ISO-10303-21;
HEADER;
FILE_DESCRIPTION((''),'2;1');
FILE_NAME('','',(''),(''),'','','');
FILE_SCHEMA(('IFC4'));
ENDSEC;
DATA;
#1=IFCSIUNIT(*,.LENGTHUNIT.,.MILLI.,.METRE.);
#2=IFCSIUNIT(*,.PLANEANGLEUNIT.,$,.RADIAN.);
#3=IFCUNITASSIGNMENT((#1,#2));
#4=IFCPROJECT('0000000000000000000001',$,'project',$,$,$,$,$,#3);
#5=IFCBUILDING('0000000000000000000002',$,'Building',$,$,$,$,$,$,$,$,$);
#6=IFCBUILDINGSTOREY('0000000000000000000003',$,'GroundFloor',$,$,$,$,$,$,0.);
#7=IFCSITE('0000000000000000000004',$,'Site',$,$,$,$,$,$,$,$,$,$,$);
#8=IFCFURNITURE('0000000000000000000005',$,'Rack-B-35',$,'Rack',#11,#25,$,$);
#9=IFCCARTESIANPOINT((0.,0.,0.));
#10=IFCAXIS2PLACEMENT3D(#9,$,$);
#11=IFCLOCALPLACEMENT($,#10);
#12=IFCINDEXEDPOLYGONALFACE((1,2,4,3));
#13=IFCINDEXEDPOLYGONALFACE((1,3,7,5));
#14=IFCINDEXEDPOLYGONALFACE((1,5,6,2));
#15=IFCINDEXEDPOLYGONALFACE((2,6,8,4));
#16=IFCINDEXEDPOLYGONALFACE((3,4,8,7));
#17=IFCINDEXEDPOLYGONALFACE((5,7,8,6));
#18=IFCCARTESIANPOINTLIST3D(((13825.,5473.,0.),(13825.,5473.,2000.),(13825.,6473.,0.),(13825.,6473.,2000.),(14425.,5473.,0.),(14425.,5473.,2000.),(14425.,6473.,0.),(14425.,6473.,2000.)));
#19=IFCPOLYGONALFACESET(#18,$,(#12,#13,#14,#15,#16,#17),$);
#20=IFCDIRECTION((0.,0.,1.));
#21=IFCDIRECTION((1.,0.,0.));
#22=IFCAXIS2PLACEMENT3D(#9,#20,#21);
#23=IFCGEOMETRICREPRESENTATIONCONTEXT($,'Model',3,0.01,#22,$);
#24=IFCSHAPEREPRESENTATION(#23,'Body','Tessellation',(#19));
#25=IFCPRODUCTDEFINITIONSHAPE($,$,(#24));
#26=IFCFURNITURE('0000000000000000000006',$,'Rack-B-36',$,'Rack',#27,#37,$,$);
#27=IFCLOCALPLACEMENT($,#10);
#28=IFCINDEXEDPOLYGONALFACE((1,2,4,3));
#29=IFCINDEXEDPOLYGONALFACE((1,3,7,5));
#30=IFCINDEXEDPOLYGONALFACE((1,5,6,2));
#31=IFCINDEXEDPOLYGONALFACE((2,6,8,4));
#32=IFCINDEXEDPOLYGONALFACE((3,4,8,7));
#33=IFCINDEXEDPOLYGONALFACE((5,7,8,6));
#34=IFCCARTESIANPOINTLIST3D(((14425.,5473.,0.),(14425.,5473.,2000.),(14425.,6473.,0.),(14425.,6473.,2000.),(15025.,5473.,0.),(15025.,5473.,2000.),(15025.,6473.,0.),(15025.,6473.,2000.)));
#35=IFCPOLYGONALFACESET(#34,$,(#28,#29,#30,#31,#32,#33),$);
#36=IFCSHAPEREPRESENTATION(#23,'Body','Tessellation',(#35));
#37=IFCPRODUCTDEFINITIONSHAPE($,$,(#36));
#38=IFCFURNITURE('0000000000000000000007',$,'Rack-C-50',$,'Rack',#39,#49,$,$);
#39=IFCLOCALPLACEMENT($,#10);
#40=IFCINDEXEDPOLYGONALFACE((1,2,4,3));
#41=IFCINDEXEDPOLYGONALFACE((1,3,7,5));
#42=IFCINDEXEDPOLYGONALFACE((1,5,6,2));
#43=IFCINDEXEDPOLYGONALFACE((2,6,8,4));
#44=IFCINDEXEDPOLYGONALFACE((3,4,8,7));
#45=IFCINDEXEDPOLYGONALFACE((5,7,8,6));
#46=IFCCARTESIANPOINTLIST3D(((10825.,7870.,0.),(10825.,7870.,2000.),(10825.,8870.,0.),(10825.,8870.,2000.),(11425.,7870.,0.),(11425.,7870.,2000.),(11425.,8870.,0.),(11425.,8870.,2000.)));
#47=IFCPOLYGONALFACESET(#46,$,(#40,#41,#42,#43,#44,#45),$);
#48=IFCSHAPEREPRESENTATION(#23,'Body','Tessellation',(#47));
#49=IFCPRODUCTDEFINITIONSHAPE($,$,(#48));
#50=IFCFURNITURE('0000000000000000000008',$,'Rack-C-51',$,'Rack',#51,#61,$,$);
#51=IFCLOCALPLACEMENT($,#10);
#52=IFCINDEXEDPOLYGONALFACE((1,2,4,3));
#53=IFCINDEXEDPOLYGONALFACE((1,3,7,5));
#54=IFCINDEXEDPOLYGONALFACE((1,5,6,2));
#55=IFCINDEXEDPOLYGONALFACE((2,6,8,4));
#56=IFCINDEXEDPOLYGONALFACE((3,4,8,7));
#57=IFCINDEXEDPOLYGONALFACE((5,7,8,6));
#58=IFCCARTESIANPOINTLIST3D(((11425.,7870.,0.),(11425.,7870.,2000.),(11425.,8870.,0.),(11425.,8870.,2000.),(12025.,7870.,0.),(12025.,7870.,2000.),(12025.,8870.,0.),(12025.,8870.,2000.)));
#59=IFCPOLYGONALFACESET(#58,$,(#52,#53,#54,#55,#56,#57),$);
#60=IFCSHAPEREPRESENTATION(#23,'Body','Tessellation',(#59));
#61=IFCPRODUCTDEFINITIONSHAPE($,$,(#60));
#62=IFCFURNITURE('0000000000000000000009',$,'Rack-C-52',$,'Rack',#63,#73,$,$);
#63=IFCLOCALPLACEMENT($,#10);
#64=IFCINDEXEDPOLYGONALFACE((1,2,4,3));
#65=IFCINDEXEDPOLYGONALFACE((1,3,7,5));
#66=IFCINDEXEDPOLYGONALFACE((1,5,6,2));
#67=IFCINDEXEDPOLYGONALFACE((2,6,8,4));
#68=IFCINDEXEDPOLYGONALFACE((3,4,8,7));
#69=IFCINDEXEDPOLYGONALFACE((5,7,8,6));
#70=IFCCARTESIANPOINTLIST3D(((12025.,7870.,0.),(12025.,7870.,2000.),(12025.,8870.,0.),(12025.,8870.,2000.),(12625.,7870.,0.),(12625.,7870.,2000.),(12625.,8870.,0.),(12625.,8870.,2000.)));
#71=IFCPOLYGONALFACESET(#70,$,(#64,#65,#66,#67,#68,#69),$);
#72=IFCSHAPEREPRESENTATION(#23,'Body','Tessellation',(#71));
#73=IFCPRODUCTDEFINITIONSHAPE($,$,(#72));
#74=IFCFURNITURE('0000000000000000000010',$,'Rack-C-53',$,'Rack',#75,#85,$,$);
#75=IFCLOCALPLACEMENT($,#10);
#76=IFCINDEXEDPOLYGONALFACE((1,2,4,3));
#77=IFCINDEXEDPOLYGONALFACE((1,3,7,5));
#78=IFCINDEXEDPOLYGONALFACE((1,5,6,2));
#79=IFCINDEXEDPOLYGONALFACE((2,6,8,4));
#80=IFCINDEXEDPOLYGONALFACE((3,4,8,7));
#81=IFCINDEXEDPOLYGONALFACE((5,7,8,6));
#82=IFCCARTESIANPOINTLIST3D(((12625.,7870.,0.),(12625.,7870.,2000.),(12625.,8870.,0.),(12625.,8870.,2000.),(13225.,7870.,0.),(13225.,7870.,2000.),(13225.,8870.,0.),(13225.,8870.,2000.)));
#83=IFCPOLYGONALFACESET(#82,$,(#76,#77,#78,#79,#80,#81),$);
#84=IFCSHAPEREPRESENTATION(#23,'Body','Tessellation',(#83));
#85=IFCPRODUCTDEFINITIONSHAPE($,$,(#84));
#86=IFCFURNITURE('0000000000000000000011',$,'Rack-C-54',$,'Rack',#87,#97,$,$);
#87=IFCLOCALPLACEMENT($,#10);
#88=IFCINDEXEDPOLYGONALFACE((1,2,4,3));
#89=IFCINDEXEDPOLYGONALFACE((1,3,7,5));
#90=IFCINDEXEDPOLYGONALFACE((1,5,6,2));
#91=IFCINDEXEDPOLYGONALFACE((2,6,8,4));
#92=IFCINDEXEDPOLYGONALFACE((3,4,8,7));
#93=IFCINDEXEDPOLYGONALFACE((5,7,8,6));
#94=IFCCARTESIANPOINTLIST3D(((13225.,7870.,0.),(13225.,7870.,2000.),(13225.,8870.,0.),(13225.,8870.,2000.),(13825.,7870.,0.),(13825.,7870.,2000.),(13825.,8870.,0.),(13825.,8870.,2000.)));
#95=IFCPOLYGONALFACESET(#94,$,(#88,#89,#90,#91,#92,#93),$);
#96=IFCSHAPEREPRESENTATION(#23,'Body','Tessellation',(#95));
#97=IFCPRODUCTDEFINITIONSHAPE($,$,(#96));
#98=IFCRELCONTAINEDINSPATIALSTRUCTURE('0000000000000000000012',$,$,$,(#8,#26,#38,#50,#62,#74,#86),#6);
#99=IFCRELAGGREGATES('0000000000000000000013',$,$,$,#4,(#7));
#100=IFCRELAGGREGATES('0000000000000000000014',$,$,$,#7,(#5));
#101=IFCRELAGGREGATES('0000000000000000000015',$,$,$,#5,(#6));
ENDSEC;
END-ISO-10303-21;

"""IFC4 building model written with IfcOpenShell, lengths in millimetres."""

from ifc_helpers import new_model, si_unit, frame, origin, origin_with_axes, origin_2d, place, context, project, spatial, rectangle, extrude, element, save


model = new_model("IFC4")

# Units and contexts
model_context = context("Model", 3, precision=0.01, world=origin_with_axes())
ifc_project = project(units=[si_unit("LENGTHUNIT", "METRE", prefix="MILLI"), si_unit("PLANEANGLEUNIT", "RADIAN")])

# Site, building, storey
site = spatial("IfcSite", under=ifc_project, Name="Site")
building = spatial("IfcBuilding", under=site, Name="Building")
storey = spatial("IfcBuildingStorey", under=building, Name="GroundFloor", Elevation=0.0)

# Furniture
for number, where, z_axis, x_axis, name in (
    (1, (14125.0, 5973.0, 0.0), (0.0, 0.0, 1.0), (1.0, 0.0, 0.0), "Rack-B-35"),
    (2, (14725.0, 5973.0, 0.0), (0.0, 0.0, 1.0), (1.0, 0.0, 0.0), "Rack-B-36"),
    (3, (11125.0, 8370.0, 0.0), (0.0, 0.0, 1.0), (1.0, 0.0, 0.0), "Rack-C-50"),
    (4, (11725.0, 8370.0, 0.0), (0.0, 0.0, 1.0), (1.0, 0.0, 0.0), "Rack-C-51"),
    (5, (12325.0, 8370.0, 0.0), (0.0, 0.0, 1.0), (1.0, 0.0, 0.0), "Rack-C-52"),
    (6, (12925.0, 8370.0, 0.0), (0.0, 0.0, 1.0), (1.0, 0.0, 0.0), "Rack-C-53"),
    (7, (13525.0, 8370.0, 0.0), (0.0, 0.0, 1.0), (1.0, 0.0, 0.0), "Rack-C-54"),
):
    element("IfcFurniture", number, at=place(None, frame(where, z_axis=z_axis, x_axis=x_axis)), inside=storey, Name=name, ObjectType="Rack", context=model_context, shape_type="SweptSolid", body=[
        extrude(rectangle(XDim=600.0, YDim=1000.0, at=origin_2d()), origin(), (0.0, 0.0, 1.0), 2000.0),
    ])

save(model, "model.ifc")
